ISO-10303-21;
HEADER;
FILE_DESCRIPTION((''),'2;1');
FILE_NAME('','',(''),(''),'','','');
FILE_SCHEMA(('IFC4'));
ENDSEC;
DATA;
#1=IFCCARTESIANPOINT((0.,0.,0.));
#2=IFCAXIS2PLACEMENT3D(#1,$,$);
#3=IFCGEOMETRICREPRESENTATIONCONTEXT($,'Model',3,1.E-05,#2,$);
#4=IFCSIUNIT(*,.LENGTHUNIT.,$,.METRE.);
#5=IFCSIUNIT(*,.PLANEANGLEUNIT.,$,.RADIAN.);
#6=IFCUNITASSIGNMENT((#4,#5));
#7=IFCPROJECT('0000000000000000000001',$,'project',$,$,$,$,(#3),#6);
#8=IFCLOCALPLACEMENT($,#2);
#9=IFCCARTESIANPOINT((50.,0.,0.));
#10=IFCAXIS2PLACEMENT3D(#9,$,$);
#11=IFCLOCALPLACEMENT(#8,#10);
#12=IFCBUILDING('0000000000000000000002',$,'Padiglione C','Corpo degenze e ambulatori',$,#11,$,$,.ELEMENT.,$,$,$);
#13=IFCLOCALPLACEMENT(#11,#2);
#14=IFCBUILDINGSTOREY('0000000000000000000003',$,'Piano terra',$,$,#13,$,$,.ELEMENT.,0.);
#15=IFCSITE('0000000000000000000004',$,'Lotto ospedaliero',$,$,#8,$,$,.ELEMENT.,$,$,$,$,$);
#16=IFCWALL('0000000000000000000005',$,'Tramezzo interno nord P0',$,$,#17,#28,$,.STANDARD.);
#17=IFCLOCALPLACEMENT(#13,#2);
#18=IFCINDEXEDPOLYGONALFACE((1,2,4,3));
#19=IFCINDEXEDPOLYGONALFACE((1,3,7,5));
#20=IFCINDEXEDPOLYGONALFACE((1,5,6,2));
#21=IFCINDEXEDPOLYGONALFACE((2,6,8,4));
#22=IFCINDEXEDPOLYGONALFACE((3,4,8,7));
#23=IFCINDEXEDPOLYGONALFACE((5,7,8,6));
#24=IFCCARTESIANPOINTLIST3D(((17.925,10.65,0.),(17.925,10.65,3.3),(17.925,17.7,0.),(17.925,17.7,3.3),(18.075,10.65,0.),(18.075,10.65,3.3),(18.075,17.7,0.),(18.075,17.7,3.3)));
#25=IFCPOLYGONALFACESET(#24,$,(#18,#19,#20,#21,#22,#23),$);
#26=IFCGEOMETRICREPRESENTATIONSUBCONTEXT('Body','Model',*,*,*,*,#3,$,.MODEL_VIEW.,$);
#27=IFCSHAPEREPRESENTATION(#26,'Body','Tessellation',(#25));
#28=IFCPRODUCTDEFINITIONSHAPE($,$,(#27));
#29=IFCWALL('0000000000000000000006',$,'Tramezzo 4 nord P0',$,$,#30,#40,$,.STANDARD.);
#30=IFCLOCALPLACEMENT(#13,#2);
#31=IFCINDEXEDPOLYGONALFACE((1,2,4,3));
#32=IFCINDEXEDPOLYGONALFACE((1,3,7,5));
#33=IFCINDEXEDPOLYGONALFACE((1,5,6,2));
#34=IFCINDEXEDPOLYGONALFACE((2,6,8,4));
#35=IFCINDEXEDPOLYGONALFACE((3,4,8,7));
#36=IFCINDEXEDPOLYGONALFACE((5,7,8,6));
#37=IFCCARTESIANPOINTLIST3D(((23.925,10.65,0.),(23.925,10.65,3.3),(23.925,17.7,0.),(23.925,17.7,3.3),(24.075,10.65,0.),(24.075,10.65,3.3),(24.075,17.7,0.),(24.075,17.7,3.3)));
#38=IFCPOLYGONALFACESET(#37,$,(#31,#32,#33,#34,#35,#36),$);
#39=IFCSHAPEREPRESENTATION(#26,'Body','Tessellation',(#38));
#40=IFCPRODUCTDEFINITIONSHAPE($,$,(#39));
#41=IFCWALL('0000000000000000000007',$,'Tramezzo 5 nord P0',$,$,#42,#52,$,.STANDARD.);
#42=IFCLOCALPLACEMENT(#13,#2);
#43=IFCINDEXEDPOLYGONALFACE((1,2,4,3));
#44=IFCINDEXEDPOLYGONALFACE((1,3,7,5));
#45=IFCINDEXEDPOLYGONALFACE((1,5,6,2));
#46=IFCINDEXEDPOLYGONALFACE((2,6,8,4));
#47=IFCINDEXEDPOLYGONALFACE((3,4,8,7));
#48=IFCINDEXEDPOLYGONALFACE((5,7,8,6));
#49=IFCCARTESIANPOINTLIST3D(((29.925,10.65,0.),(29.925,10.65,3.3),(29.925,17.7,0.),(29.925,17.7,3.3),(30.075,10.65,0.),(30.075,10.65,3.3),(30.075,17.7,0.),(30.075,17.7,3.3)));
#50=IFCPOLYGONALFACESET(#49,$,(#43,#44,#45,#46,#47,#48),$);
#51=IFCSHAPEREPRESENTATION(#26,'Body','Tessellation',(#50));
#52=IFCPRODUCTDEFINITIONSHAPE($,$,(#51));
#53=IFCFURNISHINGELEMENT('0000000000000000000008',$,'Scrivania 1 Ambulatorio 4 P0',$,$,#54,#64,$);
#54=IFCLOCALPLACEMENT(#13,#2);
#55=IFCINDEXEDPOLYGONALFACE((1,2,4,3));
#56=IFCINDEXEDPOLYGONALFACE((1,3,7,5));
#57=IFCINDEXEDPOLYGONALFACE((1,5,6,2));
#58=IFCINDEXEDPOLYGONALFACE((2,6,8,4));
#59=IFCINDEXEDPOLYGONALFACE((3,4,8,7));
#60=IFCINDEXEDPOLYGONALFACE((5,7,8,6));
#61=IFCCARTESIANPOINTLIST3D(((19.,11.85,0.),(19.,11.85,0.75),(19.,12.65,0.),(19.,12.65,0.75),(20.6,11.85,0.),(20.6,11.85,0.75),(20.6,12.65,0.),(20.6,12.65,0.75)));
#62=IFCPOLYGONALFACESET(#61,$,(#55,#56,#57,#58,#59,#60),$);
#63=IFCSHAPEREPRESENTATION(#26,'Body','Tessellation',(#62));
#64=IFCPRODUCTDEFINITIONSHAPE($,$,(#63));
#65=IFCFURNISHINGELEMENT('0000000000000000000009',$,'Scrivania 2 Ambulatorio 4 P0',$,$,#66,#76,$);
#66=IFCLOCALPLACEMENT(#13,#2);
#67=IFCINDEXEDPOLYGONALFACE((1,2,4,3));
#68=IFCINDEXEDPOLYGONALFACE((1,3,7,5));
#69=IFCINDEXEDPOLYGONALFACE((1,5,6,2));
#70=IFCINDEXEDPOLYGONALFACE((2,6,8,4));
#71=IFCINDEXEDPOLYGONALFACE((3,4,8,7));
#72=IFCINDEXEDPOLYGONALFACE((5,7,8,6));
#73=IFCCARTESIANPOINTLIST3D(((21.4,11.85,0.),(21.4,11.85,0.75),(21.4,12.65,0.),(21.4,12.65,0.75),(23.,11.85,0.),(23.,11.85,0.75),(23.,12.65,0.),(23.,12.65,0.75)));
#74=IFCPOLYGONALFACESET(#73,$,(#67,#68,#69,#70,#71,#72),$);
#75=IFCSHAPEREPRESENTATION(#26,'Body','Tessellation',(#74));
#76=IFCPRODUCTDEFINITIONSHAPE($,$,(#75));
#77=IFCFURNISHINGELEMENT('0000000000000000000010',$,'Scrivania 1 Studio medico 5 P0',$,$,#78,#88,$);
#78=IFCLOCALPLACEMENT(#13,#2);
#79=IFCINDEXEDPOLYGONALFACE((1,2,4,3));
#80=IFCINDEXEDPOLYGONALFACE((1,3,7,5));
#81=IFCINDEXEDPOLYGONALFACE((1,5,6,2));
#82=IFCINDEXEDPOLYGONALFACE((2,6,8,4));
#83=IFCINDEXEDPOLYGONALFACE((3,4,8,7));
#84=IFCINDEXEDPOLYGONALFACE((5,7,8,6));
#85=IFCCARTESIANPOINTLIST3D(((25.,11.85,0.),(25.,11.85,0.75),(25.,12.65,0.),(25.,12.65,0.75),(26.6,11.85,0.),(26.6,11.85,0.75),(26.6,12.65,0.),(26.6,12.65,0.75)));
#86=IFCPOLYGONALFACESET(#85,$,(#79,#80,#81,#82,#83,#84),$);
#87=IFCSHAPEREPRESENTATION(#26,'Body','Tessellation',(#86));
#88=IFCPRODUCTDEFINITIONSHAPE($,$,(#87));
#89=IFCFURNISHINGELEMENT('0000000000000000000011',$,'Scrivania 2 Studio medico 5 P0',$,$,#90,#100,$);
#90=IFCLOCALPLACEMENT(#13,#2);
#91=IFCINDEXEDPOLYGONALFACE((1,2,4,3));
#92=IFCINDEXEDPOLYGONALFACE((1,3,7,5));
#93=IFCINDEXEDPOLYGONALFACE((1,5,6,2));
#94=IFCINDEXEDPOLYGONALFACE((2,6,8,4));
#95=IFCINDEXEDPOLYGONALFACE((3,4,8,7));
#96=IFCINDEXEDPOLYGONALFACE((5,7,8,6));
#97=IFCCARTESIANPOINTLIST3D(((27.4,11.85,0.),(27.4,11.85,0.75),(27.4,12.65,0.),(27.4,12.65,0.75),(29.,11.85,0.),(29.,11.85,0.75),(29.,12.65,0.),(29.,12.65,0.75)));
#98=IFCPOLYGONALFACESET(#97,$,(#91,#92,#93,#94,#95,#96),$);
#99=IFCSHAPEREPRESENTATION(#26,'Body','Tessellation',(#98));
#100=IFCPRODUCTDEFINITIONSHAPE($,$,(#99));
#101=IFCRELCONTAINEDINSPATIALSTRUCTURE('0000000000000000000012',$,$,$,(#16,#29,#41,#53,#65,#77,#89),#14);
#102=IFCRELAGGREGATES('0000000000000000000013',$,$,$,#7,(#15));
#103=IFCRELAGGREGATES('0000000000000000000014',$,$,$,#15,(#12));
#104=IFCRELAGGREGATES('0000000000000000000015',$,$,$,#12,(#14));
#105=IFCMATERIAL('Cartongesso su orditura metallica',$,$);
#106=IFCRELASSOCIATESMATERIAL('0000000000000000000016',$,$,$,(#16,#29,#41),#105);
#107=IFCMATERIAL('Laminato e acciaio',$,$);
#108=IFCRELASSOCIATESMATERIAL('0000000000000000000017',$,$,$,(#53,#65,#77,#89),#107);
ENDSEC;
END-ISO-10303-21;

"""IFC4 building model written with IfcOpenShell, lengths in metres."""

from ifc_helpers import new_model, si_unit, frame, frame_2d, origin, place, context, subcontext, project, spatial, rectangle, extrude, material, element, save


model = new_model("IFC4")

# Units and contexts
model_context = context("Model", 3, precision=1e-05, world=origin())
body_context = subcontext(model_context, "Body", "Model", "MODEL_VIEW")
ifc_project = project(units=[si_unit("LENGTHUNIT", "METRE"), si_unit("PLANEANGLEUNIT", "RADIAN")], contexts=[model_context])

# Site, building, storey
site_placement = place(None, origin())
site = spatial("IfcSite", under=ifc_project, at=site_placement, Name="Lotto ospedaliero", CompositionType="ELEMENT")
building_placement = place(site_placement, frame((50.0, 0.0, 0.0)))
building = spatial("IfcBuilding", under=site, at=building_placement, Name="Padiglione C", Description="Corpo degenze e ambulatori", CompositionType="ELEMENT")
storey_placement = place(building_placement, origin())
storey = spatial("IfcBuildingStorey", under=building, at=storey_placement, Name="Piano terra", CompositionType="ELEMENT", Elevation=0.0)

# Walls
ifc_material_1 = material(Name="Cartongesso su orditura metallica")
for number, where, name in (
    (1, (17.925, 10.65, 0.0), "Tramezzo interno nord P0"),
    (2, (23.925, 10.65, 0.0), "Tramezzo 4 nord P0"),
    (3, (29.925, 10.65, 0.0), "Tramezzo 5 nord P0"),
):
    element("IfcWall", number, at=place(storey_placement, frame(where)), inside=storey, material=ifc_material_1, Name=name, PredefinedType="STANDARD", context=body_context, shape_type="SweptSolid", body=[
        extrude(rectangle(XDim=0.15, YDim=7.05, at=frame_2d((0.075, 3.525))), origin(), (0.0, 0.0, 1.0), 3.3),
    ])

# Furnishing elements
ifc_material_2 = material(Name="Laminato e acciaio")
for number, where, name in (
    (4, (19.0, 11.85, 0.0), "Scrivania 1 Ambulatorio 4 P0"),
    (5, (21.4, 11.85, 0.0), "Scrivania 2 Ambulatorio 4 P0"),
    (6, (25.0, 11.85, 0.0), "Scrivania 1 Studio medico 5 P0"),
    (7, (27.4, 11.85, 0.0), "Scrivania 2 Studio medico 5 P0"),
):
    element("IfcFurnishingElement", number, at=place(storey_placement, frame(where)), inside=storey, material=ifc_material_2, Name=name, context=body_context, shape_type="SweptSolid", body=[
        extrude(rectangle(XDim=1.6, YDim=0.8, at=frame_2d((0.8, 0.4))), origin(), (0.0, 0.0, 1.0), 0.75),
    ])

save(model, "model.ifc")
